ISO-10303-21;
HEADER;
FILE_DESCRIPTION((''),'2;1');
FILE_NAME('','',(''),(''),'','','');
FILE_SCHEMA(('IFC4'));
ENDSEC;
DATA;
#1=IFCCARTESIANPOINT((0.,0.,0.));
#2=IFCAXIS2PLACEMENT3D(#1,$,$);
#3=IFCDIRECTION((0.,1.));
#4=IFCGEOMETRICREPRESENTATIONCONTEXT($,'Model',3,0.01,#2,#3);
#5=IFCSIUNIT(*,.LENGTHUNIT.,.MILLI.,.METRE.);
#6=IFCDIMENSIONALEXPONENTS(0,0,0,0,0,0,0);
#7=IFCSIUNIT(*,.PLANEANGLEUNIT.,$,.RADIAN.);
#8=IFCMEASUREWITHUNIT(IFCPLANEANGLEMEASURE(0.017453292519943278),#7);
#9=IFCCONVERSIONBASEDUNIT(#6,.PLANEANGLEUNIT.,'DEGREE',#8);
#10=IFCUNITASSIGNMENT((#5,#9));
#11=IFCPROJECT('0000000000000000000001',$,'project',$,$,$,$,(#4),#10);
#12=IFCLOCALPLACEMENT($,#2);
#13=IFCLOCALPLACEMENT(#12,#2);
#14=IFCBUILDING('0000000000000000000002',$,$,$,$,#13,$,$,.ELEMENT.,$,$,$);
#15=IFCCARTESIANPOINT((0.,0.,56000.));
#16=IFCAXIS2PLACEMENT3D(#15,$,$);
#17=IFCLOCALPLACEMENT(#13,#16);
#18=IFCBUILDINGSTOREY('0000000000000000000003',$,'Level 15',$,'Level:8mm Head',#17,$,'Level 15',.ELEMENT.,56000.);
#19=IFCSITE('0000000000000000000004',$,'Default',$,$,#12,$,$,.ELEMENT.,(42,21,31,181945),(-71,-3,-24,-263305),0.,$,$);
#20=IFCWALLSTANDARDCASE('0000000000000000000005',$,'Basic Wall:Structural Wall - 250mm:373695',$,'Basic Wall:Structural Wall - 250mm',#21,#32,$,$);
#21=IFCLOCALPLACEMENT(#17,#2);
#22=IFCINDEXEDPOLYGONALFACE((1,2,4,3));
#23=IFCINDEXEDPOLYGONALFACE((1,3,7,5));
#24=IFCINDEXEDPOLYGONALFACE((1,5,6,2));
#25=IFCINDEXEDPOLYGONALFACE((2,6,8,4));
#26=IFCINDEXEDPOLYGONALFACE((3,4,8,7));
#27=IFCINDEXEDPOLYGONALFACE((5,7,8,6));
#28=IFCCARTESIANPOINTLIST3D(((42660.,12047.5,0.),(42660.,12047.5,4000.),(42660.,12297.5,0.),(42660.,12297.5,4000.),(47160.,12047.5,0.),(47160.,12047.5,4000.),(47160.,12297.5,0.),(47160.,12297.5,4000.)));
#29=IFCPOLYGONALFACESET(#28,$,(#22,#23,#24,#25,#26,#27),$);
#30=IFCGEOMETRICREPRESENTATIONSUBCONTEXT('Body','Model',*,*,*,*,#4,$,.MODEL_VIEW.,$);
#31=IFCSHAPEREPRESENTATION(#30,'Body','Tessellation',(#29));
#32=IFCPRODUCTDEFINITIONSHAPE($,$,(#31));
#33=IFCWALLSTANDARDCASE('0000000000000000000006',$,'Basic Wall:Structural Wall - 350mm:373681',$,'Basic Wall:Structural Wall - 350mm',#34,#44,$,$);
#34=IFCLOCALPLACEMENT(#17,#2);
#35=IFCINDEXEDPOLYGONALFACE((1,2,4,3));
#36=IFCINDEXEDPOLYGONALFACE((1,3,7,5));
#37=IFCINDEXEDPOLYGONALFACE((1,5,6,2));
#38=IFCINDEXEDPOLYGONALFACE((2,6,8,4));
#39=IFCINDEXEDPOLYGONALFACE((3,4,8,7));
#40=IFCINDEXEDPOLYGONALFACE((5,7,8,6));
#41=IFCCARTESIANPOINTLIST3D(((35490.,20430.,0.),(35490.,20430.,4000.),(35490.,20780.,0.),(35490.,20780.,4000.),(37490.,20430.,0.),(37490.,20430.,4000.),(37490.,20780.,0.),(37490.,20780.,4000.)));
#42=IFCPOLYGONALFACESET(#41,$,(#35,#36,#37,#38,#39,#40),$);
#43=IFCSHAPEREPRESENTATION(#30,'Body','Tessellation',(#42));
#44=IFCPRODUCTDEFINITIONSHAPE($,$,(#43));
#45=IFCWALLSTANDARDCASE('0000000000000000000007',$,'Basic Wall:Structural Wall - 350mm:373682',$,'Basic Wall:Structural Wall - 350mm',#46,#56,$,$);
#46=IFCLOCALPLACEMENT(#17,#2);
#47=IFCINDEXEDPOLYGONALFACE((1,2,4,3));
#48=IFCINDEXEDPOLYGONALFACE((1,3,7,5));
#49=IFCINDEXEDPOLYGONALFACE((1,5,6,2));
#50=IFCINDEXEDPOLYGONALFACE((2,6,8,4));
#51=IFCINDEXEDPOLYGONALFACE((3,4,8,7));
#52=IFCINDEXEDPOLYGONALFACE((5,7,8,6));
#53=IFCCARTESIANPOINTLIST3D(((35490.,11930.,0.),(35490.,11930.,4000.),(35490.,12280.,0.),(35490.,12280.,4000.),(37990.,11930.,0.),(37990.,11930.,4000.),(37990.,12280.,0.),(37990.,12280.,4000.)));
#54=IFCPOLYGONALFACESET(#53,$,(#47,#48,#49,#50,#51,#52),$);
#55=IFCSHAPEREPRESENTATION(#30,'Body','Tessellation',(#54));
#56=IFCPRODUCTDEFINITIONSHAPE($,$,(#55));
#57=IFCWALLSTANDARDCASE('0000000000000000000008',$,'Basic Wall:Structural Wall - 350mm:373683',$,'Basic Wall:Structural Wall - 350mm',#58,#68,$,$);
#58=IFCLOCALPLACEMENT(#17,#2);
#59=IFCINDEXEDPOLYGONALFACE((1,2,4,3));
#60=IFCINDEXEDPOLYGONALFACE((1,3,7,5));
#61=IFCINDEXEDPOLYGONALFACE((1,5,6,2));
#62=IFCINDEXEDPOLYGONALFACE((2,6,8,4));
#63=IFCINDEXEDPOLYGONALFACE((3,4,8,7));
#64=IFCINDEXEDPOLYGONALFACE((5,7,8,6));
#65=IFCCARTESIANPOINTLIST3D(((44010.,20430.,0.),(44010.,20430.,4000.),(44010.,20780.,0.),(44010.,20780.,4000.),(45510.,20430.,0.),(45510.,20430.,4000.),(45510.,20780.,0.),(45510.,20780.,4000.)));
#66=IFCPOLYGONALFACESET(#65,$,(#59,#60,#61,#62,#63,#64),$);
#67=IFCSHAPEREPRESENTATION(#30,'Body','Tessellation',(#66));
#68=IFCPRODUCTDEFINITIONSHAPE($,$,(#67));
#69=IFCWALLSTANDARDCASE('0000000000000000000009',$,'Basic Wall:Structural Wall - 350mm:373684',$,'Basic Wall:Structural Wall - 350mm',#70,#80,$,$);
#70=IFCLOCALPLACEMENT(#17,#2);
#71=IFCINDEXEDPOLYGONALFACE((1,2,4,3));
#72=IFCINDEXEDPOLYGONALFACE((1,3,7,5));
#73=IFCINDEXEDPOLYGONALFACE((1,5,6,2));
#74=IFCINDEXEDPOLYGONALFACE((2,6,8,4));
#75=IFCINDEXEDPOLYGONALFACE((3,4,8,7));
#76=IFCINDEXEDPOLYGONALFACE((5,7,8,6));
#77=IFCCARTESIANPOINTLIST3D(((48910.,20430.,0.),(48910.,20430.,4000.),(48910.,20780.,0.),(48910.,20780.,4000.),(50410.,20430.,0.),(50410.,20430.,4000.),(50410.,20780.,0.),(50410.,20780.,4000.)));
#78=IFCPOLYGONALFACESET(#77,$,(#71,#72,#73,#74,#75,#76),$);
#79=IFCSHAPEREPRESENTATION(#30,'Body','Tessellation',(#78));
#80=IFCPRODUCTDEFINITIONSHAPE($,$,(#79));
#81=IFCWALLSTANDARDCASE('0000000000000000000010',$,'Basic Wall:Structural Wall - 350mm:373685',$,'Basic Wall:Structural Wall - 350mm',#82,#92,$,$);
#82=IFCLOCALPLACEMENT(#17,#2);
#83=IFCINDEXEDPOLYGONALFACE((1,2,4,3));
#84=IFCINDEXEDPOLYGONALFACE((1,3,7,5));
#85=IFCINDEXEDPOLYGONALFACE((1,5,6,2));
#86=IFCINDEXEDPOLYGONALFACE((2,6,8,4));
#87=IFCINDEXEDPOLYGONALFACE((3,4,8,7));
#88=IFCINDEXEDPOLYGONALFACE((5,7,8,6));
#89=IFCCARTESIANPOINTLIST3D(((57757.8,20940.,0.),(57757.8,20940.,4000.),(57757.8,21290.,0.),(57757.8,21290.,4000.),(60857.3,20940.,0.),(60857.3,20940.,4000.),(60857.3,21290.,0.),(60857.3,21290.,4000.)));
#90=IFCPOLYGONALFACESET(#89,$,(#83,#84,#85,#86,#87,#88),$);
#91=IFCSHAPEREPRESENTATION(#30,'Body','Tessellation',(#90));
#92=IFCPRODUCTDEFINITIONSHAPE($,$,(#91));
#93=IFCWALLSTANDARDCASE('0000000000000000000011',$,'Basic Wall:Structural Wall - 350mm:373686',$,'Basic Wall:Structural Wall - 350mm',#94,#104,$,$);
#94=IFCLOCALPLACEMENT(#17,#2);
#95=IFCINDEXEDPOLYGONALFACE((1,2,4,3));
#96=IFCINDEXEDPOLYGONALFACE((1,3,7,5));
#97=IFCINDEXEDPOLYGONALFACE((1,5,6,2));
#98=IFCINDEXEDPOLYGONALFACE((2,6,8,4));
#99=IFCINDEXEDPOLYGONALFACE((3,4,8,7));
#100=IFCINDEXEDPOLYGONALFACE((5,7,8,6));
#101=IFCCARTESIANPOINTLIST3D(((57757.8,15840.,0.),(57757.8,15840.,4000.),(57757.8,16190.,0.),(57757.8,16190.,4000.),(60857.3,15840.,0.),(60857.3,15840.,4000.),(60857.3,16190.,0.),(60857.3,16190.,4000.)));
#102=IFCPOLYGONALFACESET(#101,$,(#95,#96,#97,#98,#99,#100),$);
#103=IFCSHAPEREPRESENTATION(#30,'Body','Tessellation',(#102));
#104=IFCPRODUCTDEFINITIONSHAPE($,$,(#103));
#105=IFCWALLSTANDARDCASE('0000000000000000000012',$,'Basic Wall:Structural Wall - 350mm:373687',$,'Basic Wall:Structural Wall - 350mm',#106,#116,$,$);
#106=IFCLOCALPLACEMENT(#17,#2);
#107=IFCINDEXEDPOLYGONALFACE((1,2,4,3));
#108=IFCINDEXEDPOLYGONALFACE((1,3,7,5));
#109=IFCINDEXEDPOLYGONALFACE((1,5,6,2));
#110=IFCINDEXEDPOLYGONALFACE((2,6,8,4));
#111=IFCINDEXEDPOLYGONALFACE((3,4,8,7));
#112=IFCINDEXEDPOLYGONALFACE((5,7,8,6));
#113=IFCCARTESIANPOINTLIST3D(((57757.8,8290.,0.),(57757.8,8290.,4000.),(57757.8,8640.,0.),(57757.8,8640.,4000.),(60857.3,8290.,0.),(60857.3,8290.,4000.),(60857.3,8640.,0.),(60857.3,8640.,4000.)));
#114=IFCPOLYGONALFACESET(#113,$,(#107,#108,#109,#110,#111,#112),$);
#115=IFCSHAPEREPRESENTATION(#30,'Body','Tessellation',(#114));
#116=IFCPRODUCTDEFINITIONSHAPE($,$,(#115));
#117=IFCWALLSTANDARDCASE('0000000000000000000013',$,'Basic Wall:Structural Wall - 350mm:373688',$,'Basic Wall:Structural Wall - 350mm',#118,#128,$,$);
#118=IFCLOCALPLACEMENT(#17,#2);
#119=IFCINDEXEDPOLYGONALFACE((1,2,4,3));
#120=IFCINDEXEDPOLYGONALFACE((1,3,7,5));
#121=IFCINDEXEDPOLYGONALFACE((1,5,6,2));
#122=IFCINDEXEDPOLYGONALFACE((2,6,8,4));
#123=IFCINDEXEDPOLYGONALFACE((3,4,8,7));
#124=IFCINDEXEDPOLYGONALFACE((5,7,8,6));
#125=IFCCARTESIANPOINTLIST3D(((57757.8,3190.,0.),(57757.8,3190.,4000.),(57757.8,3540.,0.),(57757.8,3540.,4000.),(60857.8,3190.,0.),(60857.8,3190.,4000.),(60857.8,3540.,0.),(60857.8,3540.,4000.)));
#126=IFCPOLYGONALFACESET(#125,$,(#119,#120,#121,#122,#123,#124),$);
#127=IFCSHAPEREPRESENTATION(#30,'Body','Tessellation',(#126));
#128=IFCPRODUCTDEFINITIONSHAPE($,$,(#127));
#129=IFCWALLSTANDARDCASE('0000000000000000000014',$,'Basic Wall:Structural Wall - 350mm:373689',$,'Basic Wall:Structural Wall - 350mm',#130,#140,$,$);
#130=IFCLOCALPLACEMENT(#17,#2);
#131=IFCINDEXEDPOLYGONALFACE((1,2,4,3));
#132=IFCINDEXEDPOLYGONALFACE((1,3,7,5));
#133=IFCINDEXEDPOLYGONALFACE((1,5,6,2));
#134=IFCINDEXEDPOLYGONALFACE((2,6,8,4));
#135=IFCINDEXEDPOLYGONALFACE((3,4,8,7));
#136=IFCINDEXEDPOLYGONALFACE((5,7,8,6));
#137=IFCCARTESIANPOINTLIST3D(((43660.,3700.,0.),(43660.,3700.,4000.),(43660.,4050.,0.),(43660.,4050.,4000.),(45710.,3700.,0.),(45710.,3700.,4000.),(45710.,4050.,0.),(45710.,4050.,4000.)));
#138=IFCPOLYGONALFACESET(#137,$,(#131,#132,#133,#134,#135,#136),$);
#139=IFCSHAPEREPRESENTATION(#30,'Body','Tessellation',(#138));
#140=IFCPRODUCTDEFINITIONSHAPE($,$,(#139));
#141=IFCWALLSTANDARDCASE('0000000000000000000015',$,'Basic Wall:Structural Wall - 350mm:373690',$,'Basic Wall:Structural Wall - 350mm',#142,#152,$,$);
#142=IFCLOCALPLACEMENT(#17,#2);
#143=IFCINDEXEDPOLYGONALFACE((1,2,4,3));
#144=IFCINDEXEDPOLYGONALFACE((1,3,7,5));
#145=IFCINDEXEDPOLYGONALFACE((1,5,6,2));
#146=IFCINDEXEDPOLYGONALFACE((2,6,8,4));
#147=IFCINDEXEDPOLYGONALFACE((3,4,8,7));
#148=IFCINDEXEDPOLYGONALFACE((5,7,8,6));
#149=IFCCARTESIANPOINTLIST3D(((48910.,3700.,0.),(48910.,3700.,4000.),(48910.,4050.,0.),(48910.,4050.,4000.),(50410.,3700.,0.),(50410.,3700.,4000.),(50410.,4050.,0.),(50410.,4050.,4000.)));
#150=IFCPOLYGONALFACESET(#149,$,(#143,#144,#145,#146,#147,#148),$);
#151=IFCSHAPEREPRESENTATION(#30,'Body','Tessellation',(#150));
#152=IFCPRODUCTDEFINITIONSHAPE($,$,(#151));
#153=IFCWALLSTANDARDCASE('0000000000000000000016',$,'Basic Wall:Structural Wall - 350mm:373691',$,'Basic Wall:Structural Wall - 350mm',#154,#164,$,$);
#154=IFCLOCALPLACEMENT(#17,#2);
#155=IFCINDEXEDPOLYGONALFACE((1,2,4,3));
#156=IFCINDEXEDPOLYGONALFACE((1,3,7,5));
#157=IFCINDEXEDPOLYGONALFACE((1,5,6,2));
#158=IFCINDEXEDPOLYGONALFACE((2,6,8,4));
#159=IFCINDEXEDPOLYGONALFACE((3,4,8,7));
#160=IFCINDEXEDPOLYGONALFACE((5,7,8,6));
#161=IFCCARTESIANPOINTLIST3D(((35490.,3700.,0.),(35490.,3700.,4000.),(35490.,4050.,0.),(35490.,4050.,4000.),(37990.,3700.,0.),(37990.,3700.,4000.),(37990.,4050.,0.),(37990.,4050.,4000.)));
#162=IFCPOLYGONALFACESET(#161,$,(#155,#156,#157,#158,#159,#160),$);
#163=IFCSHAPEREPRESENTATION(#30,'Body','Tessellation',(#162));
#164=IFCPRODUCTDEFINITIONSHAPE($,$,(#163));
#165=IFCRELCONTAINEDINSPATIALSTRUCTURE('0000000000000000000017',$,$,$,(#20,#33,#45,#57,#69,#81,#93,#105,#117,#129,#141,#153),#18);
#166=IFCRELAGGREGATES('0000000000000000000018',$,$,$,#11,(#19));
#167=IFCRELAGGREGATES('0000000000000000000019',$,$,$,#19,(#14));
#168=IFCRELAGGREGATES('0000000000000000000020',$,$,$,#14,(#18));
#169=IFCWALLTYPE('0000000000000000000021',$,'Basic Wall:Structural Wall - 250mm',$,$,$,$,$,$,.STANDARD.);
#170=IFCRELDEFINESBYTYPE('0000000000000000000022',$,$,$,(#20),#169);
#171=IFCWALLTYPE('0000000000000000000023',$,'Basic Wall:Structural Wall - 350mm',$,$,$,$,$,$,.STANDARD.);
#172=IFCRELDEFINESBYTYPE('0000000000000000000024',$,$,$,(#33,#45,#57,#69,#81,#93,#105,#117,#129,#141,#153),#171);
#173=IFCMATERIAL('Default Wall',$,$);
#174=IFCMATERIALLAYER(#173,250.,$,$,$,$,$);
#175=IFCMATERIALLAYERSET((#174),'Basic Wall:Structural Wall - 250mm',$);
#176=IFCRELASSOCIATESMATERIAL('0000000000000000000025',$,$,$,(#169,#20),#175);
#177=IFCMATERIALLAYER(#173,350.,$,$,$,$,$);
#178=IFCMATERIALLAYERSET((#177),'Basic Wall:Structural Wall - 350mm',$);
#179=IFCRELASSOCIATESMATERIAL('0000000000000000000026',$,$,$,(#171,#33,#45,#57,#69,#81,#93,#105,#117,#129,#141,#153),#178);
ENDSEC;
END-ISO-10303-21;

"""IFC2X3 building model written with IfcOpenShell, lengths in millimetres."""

from ifc_helpers import new_model, entity, si_unit, converted_unit, direction, frame, frame_2d, origin, place, context, subcontext, project, spatial, rectangle, extrude, material, layer, layer_set, layer_usage, type_object, element, save


model = new_model("IFC2X3")

# Units and contexts
model_context = context("Model", 3, precision=0.01, world=origin(), true_north=direction((0.0, 1.0)))
body_context = subcontext(model_context, "Body", "Model", "MODEL_VIEW")
ifc_project = project(units=[si_unit("LENGTHUNIT", "METRE", prefix="MILLI"), converted_unit("PLANEANGLEUNIT", "DEGREE", entity("IfcPlaneAngleMeasure", 0.017453292519943278), si_unit("PLANEANGLEUNIT", "RADIAN"), dimensions=[0, 0, 0, 0, 0, 0, 0])], contexts=[model_context])

# Site, building, storey
site_placement = place(None, origin())
site = spatial("IfcSite", under=ifc_project, at=site_placement, Name="Default", CompositionType="ELEMENT", RefLatitude=(42, 21, 31, 181945), RefLongitude=(-71, -3, -24, -263305), RefElevation=0.0)
building_placement = place(site_placement, origin())
building = spatial("IfcBuilding", under=site, at=building_placement, CompositionType="ELEMENT")
storey_placement = place(building_placement, frame((0.0, 0.0, 56000.0)))
storey = spatial("IfcBuildingStorey", under=building, at=storey_placement, Name="Level 15", ObjectType="Level:8mm Head", LongName="Level 15", CompositionType="ELEMENT", Elevation=56000.0)

# Walls
ifc_material_1 = material(Name="Default Wall")
ifc_layer_1 = layer(ifc_material_1, 250.0)
ifc_layer_set_1 = layer_set([ifc_layer_1], Name="Basic Wall:Structural Wall - 250mm")
ifc_layer_usage_1 = layer_usage(ifc_layer_set_1, "AXIS2", "NEGATIVE", 125.0)
wall_type_1 = type_object("IfcWallType", Name="Basic Wall:Structural Wall - 250mm", PredefinedType="STANDARD", material=ifc_layer_set_1)
wall_1_placement = place(storey_placement, frame((42660.0, 12172.5, 0.0)))
element("IfcWallStandardCase", 1, at=wall_1_placement, inside=storey, type_object=wall_type_1, material=ifc_layer_usage_1, Name="Basic Wall:Structural Wall - 250mm:373695", ObjectType="Basic Wall:Structural Wall - 250mm", context=body_context, shape_type="SweptSolid", body=[
    extrude(rectangle(XDim=4500.0, YDim=250.0, at=frame_2d((2250.0, 0.0), x_axis=(-1.0, 0.0))), origin(), (0.0, 0.0, 1.0), 4000.0),
])
ifc_layer_2 = layer(ifc_material_1, 350.0)
ifc_layer_set_2 = layer_set([ifc_layer_2], Name="Basic Wall:Structural Wall - 350mm")
ifc_layer_usage_2 = layer_usage(ifc_layer_set_2, "AXIS2", "NEGATIVE", 175.0)
wall_type_2 = type_object("IfcWallType", Name="Basic Wall:Structural Wall - 350mm", PredefinedType="STANDARD", material=ifc_layer_set_2)
wall_2_placement = place(storey_placement, frame((35490.0, 20605.0, 0.0)))
element("IfcWallStandardCase", 2, at=wall_2_placement, inside=storey, type_object=wall_type_2, material=ifc_layer_usage_2, Name="Basic Wall:Structural Wall - 350mm:373681", ObjectType="Basic Wall:Structural Wall - 350mm", context=body_context, shape_type="SweptSolid", body=[
    extrude(rectangle(XDim=2000.0, YDim=350.0, at=frame_2d((1000.0, 0.0), x_axis=(-1.0, 0.0))), origin(), (0.0, 0.0, 1.0), 4000.0),
])
ifc_layer_usage_3 = layer_usage(ifc_layer_set_2, "AXIS2", "POSITIVE", -175.0)
wall_3_placement = place(storey_placement, frame((35490.0, 12105.0, 0.0)))
element("IfcWallStandardCase", 3, at=wall_3_placement, inside=storey, type_object=wall_type_2, material=ifc_layer_usage_3, Name="Basic Wall:Structural Wall - 350mm:373682", ObjectType="Basic Wall:Structural Wall - 350mm", context=body_context, shape_type="SweptSolid", body=[
    extrude(rectangle(XDim=2500.0, YDim=350.0, at=frame_2d((1250.0, 0.0), x_axis=(-1.0, 0.0))), origin(), (0.0, 0.0, 1.0), 4000.0),
])
ifc_layer_usage_4 = layer_usage(ifc_layer_set_2, "AXIS2", "NEGATIVE", 175.0)
wall_4_placement = place(storey_placement, frame((44010.0, 20605.0, 0.0)))
element("IfcWallStandardCase", 4, at=wall_4_placement, inside=storey, type_object=wall_type_2, material=ifc_layer_usage_4, Name="Basic Wall:Structural Wall - 350mm:373683", ObjectType="Basic Wall:Structural Wall - 350mm", context=body_context, shape_type="SweptSolid", body=[
    extrude(rectangle(XDim=1500.0, YDim=350.0, at=frame_2d((750.0, 0.0), x_axis=(-1.0, 0.0))), origin(), (0.0, 0.0, 1.0), 4000.0),
])
ifc_layer_usage_5 = layer_usage(ifc_layer_set_2, "AXIS2", "NEGATIVE", 175.0)
wall_5_placement = place(storey_placement, frame((48910.0, 20605.0, 0.0)))
element("IfcWallStandardCase", 5, at=wall_5_placement, inside=storey, type_object=wall_type_2, material=ifc_layer_usage_5, Name="Basic Wall:Structural Wall - 350mm:373684", ObjectType="Basic Wall:Structural Wall - 350mm", context=body_context, shape_type="SweptSolid", body=[
    extrude(rectangle(XDim=1500.0, YDim=350.0, at=frame_2d((750.0, 0.0), x_axis=(-1.0, 0.0))), origin(), (0.0, 0.0, 1.0), 4000.0),
])
ifc_layer_usage_6 = layer_usage(ifc_layer_set_2, "AXIS2", "NEGATIVE", 175.0)
wall_6_placement = place(storey_placement, frame((57757.8, 21115.0, 0.0)))
element("IfcWallStandardCase", 6, at=wall_6_placement, inside=storey, type_object=wall_type_2, material=ifc_layer_usage_6, Name="Basic Wall:Structural Wall - 350mm:373685", ObjectType="Basic Wall:Structural Wall - 350mm", context=body_context, shape_type="SweptSolid", body=[
    extrude(rectangle(XDim=3099.5, YDim=350.0, at=frame_2d((1549.8, 0.0), x_axis=(-1.0, 0.0))), origin(), (0.0, 0.0, 1.0), 4000.0),
])
ifc_layer_usage_7 = layer_usage(ifc_layer_set_2, "AXIS2", "NEGATIVE", 175.0)
wall_7_placement = place(storey_placement, frame((57757.8, 16015.0, 0.0)))
element("IfcWallStandardCase", 7, at=wall_7_placement, inside=storey, type_object=wall_type_2, material=ifc_layer_usage_7, Name="Basic Wall:Structural Wall - 350mm:373686", ObjectType="Basic Wall:Structural Wall - 350mm", context=body_context, shape_type="SweptSolid", body=[
    extrude(rectangle(XDim=3099.5, YDim=350.0, at=frame_2d((1549.8, 0.0), x_axis=(-1.0, 0.0))), origin(), (0.0, 0.0, 1.0), 4000.0),
])
ifc_layer_usage_8 = layer_usage(ifc_layer_set_2, "AXIS2", "POSITIVE", -175.0)
wall_8_placement = place(storey_placement, frame((57757.8, 8465.0, 0.0)))
element("IfcWallStandardCase", 8, at=wall_8_placement, inside=storey, type_object=wall_type_2, material=ifc_layer_usage_8, Name="Basic Wall:Structural Wall - 350mm:373687", ObjectType="Basic Wall:Structural Wall - 350mm", context=body_context, shape_type="SweptSolid", body=[
    extrude(rectangle(XDim=3099.5, YDim=350.0, at=frame_2d((1549.8, 0.0), x_axis=(-1.0, 0.0))), origin(), (0.0, 0.0, 1.0), 4000.0),
])
ifc_layer_usage_9 = layer_usage(ifc_layer_set_2, "AXIS2", "POSITIVE", -175.0)
wall_9_placement = place(storey_placement, frame((57757.8, 3365.0, 0.0)))
element("IfcWallStandardCase", 9, at=wall_9_placement, inside=storey, type_object=wall_type_2, material=ifc_layer_usage_9, Name="Basic Wall:Structural Wall - 350mm:373688", ObjectType="Basic Wall:Structural Wall - 350mm", context=body_context, shape_type="SweptSolid", body=[
    extrude(rectangle(XDim=3100.0, YDim=350.0, at=frame_2d((1550.0, 0.0), x_axis=(-1.0, 0.0))), origin(), (0.0, 0.0, 1.0), 4000.0),
])
ifc_layer_usage_10 = layer_usage(ifc_layer_set_2, "AXIS2", "POSITIVE", -175.0)
wall_10_placement = place(storey_placement, frame((43660.0, 3875.0, 0.0)))
element("IfcWallStandardCase", 10, at=wall_10_placement, inside=storey, type_object=wall_type_2, material=ifc_layer_usage_10, Name="Basic Wall:Structural Wall - 350mm:373689", ObjectType="Basic Wall:Structural Wall - 350mm", context=body_context, shape_type="SweptSolid", body=[
    extrude(rectangle(XDim=2050.0, YDim=350.0, at=frame_2d((1025.0, 0.0), x_axis=(-1.0, 0.0))), origin(), (0.0, 0.0, 1.0), 4000.0),
])
ifc_layer_usage_11 = layer_usage(ifc_layer_set_2, "AXIS2", "POSITIVE", -175.0)
wall_11_placement = place(storey_placement, frame((48910.0, 3875.0, 0.0)))
element("IfcWallStandardCase", 11, at=wall_11_placement, inside=storey, type_object=wall_type_2, material=ifc_layer_usage_11, Name="Basic Wall:Structural Wall - 350mm:373690", ObjectType="Basic Wall:Structural Wall - 350mm", context=body_context, shape_type="SweptSolid", body=[
    extrude(rectangle(XDim=1500.0, YDim=350.0, at=frame_2d((750.0, 0.0), x_axis=(-1.0, 0.0))), origin(), (0.0, 0.0, 1.0), 4000.0),
])
ifc_layer_usage_12 = layer_usage(ifc_layer_set_2, "AXIS2", "POSITIVE", -175.0)
wall_12_placement = place(storey_placement, frame((35490.0, 3875.0, 0.0)))
element("IfcWallStandardCase", 12, at=wall_12_placement, inside=storey, type_object=wall_type_2, material=ifc_layer_usage_12, Name="Basic Wall:Structural Wall - 350mm:373691", ObjectType="Basic Wall:Structural Wall - 350mm", context=body_context, shape_type="SweptSolid", body=[
    extrude(rectangle(XDim=2500.0, YDim=350.0, at=frame_2d((1250.0, 0.0), x_axis=(-1.0, 0.0))), origin(), (0.0, 0.0, 1.0), 4000.0),
])

save(model, "model.ifc")
